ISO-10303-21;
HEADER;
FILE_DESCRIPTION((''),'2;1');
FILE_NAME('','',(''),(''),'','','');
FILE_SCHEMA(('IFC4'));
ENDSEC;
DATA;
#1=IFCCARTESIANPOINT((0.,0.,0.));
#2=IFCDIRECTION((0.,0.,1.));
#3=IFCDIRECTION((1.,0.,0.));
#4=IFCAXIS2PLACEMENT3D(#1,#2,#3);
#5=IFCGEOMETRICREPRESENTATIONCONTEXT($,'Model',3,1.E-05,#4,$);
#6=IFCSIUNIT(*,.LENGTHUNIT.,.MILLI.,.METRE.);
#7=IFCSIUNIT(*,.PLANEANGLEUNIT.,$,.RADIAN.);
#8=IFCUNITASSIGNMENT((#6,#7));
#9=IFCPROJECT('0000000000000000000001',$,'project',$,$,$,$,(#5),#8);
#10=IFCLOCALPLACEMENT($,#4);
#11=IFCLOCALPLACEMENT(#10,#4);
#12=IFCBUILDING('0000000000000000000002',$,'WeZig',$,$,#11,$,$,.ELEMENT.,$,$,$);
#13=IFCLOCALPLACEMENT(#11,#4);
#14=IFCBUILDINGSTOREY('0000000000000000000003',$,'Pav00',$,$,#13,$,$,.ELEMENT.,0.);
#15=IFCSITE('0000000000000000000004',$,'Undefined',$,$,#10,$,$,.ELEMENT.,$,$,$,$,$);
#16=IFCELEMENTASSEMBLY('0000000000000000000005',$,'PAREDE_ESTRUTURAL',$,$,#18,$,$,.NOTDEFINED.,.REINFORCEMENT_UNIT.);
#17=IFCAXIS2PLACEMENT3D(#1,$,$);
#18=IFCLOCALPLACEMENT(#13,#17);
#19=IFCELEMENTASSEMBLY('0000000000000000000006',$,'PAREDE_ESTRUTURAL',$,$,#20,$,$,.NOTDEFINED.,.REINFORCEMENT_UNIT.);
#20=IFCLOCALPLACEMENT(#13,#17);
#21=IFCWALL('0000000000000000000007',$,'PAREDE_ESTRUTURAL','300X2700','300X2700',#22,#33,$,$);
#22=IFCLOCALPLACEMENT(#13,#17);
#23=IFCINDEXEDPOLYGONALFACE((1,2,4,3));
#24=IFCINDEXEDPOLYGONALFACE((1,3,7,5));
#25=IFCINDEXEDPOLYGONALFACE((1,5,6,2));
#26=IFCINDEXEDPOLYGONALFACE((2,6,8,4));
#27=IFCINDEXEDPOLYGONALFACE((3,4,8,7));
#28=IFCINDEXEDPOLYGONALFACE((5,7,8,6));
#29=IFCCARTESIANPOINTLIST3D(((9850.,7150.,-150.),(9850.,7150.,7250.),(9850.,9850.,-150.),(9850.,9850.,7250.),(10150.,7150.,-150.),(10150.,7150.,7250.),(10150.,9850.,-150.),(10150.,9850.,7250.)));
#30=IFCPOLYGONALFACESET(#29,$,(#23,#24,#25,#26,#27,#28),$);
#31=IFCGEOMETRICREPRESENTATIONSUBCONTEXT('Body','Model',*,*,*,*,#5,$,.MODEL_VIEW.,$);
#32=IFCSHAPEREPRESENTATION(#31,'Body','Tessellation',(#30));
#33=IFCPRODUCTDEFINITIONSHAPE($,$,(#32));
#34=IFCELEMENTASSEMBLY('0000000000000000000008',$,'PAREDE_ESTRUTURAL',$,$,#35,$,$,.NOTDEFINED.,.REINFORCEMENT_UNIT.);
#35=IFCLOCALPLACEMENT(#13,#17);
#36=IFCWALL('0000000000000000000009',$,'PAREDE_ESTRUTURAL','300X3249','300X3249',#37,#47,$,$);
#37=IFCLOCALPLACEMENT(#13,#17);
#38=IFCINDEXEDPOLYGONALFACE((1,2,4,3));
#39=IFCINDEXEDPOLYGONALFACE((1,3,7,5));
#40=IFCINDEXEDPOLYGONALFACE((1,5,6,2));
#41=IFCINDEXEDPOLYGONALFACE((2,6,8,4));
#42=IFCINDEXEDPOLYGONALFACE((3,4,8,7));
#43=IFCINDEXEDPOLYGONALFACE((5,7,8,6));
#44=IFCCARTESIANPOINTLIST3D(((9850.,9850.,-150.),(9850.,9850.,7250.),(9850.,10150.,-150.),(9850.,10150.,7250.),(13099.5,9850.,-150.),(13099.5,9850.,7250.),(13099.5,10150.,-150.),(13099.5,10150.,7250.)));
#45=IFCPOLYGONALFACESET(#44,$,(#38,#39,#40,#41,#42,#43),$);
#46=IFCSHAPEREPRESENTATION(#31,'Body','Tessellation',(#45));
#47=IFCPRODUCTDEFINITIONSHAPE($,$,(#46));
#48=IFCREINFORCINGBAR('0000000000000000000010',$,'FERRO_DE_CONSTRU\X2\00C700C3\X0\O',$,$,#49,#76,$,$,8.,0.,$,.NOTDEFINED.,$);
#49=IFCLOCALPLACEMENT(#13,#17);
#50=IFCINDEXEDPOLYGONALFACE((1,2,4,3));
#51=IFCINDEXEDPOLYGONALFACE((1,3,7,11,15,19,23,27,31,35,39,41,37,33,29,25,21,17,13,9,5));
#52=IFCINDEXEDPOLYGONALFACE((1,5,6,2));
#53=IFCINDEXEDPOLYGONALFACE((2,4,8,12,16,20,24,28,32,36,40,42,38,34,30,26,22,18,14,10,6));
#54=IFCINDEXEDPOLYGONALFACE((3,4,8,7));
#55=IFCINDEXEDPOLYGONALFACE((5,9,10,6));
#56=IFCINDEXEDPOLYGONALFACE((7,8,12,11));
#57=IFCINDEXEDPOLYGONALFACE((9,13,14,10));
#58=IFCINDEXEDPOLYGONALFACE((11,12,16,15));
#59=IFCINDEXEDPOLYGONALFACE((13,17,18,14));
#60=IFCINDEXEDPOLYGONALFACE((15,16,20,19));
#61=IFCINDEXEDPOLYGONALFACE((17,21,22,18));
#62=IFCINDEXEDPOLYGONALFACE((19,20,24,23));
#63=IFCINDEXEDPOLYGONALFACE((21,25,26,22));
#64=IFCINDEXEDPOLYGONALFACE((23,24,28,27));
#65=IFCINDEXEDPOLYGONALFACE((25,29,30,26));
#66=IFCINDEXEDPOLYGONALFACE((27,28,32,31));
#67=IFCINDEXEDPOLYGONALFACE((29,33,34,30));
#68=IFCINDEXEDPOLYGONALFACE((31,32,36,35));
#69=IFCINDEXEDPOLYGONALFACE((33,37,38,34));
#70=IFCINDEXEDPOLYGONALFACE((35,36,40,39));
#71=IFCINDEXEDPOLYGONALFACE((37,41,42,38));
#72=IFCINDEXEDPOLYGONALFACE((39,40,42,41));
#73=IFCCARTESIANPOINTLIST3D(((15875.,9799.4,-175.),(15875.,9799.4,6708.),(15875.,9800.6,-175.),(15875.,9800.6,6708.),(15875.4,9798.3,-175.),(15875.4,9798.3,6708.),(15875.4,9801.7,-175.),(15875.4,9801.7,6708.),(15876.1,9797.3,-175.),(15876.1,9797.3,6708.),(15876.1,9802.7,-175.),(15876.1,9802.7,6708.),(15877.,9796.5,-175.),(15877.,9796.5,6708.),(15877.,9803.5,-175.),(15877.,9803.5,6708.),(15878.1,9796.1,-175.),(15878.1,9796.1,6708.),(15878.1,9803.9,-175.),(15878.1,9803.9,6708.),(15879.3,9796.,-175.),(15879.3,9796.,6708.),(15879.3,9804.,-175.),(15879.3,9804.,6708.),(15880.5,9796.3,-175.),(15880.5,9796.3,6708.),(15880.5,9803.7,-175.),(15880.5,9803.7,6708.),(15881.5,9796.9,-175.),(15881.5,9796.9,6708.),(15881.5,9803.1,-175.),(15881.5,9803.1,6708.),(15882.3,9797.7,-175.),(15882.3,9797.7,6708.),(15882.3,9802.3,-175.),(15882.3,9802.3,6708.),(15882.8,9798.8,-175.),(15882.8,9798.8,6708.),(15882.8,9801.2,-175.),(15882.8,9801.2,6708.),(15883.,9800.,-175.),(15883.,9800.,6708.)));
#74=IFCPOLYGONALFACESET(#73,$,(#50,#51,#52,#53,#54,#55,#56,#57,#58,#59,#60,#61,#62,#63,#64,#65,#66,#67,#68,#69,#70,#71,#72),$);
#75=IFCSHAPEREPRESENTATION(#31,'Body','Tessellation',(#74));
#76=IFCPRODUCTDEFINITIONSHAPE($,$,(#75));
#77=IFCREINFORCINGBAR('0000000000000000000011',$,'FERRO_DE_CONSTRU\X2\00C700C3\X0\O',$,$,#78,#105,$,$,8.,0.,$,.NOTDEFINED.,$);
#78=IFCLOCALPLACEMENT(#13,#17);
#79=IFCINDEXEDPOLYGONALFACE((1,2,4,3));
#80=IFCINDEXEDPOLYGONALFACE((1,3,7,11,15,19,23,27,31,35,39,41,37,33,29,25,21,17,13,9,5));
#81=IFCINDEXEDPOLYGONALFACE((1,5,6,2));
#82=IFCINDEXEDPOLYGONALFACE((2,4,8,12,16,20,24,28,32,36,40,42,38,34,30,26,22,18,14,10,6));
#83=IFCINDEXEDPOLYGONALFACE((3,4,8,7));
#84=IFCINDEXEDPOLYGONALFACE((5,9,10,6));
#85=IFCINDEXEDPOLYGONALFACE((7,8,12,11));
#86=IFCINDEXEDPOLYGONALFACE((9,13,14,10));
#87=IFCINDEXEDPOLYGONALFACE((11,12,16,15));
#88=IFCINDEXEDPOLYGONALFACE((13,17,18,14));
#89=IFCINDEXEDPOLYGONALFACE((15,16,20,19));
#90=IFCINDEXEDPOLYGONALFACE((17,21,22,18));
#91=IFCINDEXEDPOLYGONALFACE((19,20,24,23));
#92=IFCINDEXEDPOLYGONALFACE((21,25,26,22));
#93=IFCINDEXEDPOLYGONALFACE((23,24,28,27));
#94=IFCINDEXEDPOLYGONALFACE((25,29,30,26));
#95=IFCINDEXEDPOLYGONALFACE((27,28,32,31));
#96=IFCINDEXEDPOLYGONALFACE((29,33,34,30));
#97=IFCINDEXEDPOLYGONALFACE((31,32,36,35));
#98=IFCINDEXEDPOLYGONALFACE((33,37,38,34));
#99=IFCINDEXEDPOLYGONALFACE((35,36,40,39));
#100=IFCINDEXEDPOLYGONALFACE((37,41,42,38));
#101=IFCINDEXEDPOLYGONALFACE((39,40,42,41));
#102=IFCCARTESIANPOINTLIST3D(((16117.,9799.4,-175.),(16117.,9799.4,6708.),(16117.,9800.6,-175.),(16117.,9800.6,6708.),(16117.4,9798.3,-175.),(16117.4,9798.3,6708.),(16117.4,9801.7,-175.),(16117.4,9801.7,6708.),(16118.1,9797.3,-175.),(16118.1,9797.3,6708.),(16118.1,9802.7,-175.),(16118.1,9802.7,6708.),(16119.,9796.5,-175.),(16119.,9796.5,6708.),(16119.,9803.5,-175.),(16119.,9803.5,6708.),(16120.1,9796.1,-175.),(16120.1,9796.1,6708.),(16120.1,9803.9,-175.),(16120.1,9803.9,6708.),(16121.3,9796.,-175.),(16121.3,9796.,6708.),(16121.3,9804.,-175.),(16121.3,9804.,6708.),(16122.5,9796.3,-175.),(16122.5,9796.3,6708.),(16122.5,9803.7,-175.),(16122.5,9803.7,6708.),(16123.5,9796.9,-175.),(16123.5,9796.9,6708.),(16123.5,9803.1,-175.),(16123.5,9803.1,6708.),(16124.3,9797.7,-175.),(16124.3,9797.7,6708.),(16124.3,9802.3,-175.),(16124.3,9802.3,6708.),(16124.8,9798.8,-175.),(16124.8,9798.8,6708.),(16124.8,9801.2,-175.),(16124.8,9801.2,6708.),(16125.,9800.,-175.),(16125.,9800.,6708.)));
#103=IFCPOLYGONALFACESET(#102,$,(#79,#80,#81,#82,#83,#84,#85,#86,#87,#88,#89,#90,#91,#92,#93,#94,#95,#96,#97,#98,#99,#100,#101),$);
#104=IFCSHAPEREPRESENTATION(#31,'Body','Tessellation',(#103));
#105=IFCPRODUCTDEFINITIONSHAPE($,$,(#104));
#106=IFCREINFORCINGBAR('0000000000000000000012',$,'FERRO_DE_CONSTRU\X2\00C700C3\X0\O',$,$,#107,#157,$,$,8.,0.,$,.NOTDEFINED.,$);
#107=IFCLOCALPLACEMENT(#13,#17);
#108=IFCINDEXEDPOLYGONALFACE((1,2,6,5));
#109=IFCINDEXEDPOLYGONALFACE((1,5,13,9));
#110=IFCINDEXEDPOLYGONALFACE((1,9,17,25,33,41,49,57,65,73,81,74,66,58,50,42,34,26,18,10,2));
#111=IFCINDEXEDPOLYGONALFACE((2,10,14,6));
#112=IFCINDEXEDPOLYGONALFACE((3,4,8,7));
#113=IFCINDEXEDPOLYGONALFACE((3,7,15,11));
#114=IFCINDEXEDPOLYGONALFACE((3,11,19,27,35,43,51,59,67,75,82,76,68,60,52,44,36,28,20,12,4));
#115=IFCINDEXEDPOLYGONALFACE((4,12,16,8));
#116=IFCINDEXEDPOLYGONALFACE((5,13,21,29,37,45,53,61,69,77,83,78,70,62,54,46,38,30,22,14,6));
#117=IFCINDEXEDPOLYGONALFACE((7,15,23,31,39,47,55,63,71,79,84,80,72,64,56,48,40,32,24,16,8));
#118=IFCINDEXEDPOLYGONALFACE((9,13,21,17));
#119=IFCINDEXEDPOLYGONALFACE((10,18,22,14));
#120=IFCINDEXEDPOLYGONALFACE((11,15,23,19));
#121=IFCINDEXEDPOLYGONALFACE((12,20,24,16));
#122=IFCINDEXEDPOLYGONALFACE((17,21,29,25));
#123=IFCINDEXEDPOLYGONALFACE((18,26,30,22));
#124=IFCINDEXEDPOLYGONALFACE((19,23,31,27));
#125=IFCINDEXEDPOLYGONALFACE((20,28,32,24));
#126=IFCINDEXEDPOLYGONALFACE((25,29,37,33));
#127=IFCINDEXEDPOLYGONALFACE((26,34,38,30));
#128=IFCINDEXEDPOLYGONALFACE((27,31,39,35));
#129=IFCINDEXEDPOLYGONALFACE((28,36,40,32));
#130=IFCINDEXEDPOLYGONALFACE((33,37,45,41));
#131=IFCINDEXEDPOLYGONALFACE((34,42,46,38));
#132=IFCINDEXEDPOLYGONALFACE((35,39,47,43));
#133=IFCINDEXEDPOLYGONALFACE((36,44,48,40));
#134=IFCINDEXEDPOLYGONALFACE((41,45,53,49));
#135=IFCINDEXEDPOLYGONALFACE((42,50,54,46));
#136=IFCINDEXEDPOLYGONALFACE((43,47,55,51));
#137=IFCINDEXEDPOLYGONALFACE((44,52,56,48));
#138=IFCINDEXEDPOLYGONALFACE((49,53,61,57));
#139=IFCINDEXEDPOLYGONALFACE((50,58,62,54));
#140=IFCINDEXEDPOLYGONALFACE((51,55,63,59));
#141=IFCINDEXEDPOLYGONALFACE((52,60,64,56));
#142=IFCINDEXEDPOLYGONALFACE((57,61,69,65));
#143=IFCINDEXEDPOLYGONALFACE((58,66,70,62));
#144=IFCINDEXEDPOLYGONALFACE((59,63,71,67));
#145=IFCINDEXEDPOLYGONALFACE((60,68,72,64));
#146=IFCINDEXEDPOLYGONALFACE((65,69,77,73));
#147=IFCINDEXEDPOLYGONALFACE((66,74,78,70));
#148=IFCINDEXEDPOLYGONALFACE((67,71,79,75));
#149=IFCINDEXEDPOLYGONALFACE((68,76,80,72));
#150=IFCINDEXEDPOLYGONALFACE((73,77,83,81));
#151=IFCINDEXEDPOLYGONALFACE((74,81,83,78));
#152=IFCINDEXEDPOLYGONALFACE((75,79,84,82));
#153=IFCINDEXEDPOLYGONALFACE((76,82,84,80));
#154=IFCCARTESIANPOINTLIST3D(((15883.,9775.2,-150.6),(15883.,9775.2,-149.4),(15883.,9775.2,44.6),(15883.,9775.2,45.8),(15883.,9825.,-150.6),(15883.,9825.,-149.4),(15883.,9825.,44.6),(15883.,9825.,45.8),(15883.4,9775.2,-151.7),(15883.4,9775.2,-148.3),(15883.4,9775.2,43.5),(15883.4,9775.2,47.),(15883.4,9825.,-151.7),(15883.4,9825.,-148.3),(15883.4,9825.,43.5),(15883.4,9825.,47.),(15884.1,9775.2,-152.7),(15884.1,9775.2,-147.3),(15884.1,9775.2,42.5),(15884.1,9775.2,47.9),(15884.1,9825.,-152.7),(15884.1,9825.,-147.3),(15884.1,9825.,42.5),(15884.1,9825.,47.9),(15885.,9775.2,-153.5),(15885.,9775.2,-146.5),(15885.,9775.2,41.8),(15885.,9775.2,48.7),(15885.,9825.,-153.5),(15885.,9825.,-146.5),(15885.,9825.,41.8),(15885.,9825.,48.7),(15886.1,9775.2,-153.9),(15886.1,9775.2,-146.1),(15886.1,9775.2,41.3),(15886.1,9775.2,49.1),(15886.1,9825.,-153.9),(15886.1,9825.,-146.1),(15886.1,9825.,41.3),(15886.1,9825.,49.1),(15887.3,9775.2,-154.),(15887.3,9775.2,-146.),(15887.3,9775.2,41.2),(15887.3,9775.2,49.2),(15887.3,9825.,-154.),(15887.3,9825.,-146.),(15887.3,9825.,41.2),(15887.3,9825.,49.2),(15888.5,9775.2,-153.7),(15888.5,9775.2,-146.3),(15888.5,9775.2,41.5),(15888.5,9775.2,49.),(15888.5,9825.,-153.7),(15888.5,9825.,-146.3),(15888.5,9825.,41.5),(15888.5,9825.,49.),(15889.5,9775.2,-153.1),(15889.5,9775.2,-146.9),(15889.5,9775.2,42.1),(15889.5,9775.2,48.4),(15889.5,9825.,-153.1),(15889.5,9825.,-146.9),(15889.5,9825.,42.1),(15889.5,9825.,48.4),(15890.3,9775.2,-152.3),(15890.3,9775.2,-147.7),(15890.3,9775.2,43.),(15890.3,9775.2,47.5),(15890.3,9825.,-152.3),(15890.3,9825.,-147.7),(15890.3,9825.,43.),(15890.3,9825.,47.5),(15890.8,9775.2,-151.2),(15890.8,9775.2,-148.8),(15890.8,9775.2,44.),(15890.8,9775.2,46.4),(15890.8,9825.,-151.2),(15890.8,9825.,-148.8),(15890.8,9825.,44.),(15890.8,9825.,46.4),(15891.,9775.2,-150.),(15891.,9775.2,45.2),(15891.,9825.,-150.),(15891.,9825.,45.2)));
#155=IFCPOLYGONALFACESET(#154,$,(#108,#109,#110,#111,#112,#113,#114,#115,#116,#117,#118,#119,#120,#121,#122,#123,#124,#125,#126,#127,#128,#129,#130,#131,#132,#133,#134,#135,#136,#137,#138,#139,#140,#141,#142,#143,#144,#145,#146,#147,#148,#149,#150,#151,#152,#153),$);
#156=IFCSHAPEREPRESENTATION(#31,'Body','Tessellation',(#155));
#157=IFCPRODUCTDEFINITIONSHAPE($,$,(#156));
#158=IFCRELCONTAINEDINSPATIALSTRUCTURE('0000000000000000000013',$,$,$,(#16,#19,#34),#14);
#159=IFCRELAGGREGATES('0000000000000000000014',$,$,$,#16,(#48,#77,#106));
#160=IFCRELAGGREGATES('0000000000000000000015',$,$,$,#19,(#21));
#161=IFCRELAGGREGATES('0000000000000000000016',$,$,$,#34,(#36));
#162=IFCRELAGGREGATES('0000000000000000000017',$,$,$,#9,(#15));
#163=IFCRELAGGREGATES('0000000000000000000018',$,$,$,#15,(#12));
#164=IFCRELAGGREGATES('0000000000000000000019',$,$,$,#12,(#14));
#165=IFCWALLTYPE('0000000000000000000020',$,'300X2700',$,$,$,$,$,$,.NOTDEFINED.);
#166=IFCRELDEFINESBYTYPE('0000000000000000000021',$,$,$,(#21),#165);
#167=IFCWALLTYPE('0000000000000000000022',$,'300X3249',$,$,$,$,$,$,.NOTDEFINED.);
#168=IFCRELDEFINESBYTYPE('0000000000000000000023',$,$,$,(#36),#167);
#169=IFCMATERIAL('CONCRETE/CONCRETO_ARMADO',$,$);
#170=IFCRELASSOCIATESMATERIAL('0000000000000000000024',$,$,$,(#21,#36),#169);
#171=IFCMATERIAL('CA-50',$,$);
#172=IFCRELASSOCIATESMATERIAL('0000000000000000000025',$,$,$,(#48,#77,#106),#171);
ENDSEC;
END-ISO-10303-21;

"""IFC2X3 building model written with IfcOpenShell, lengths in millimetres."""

from ifc_helpers import new_model, entity, si_unit, frame, frame_2d, origin_with_axes, place, context, subcontext, project, spatial, rectangle, extrude, source, transform, mapped, material, type_object, element, aggregate, save


model = new_model("IFC2X3")

# Units and contexts
model_context = context("Model", 3, precision=1e-05, world=origin_with_axes())
body_context = subcontext(model_context, "Body", "Model", "MODEL_VIEW")
ifc_project = project(units=[si_unit("LENGTHUNIT", "METRE", prefix="MILLI"), si_unit("PLANEANGLEUNIT", "RADIAN")], contexts=[model_context])

# Site, building, storey
site_placement = place(None, origin_with_axes())
site = spatial("IfcSite", under=ifc_project, at=site_placement, Name="Undefined", CompositionType="ELEMENT")
building_placement = place(site_placement, origin_with_axes())
building = spatial("IfcBuilding", under=site, at=building_placement, Name="WeZig", CompositionType="ELEMENT")
storey_placement = place(building_placement, origin_with_axes())
storey = spatial("IfcBuildingStorey", under=building, at=storey_placement, Name="Pav00", CompositionType="ELEMENT", Elevation=0.0)

# Element assemblies, walls
assembly_1_placement = place(storey_placement, origin_with_axes())
assembly_1 = element("IfcElementAssembly", 1, at=assembly_1_placement, inside=storey, Name="PAREDE_ESTRUTURAL", AssemblyPlace="NOTDEFINED", PredefinedType="REINFORCEMENT_UNIT")
ifc_material_1 = material(Name="CONCRETE/CONCRETO_ARMADO")
wall_type_1 = type_object("IfcWallType", Name="300X2700", PredefinedType="NOTDEFINED")
assembly_2_placement = place(storey_placement, origin_with_axes())
assembly_2 = element("IfcElementAssembly", 2, at=assembly_2_placement, inside=storey, Name="PAREDE_ESTRUTURAL", AssemblyPlace="NOTDEFINED", PredefinedType="REINFORCEMENT_UNIT")
wall_1_placement = place(assembly_2_placement, frame((10000.0, 9850.0, 2200.0), z_axis=(0.0, 0.0, 1.0), x_axis=(0.0, -1.0, 0.0)))
wall_1 = element("IfcWall", 3, at=wall_1_placement, type_object=wall_type_1, material=ifc_material_1, Name="PAREDE_ESTRUTURAL", Description="300X2700", ObjectType="300X2700", context=body_context, shape_type="SweptSolid", body=[
    extrude(rectangle(XDim=2700.0, YDim=300.0, at=frame_2d((0.0, 1350.0), x_axis=(0.0, -1.0))), frame((0.0, 0.0, -2350.0), z_axis=(0.0, 0.0, 1.0), x_axis=(0.0, -1.0, 0.0)), (0.0, 0.0, 1.0), 7400.0),
])
assembly_3_placement = place(storey_placement, origin_with_axes())
assembly_3 = element("IfcElementAssembly", 4, at=assembly_3_placement, inside=storey, Name="PAREDE_ESTRUTURAL", AssemblyPlace="NOTDEFINED", PredefinedType="REINFORCEMENT_UNIT")
wall_type_2 = type_object("IfcWallType", Name="300X3249", PredefinedType="NOTDEFINED")
wall_2_placement = place(assembly_3_placement, frame((13099.5, 10000.0, 1925.2), z_axis=(0.0, 0.0, 1.0), x_axis=(-1.0, 0.0, 0.0)))
wall_2 = element("IfcWall", 5, at=wall_2_placement, type_object=wall_type_2, material=ifc_material_1, Name="PAREDE_ESTRUTURAL", Description="300X3249", ObjectType="300X3249", context=body_context, shape_type="SweptSolid", body=[
    extrude(rectangle(XDim=3249.5, YDim=300.0, at=frame_2d((0.0, 1624.8), x_axis=(0.0, -1.0))), frame((0.0, 0.0, -2075.2), z_axis=(0.0, 0.0, 1.0), x_axis=(0.0, -1.0, 0.0)), (0.0, 0.0, 1.0), 7400.0),
])

# Reinforcing bars
ifc_material_2 = material(Name="CA-50")
shared_shape_1 = source(origin_with_axes(), body_context, "Body", "AdvancedSweptSolid", [
    entity("IfcSweptDiskSolid", entity("IfcTrimmedCurve", entity("IfcLine", entity("IfcCartesianPoint", [0.0, 0.0, 0.0]), entity("IfcVector", entity("IfcDirection", [1.0, 0.0, 0.0]), 1.0)), [entity("IfcParameterValue", 0.0)], [entity("IfcParameterValue", 6883.0)], True, "PARAMETER"), 4.0, None, 0.0, 6883.0),
])
reinforcing_bar_1_placement = place(assembly_1_placement, frame((15879.0, 9800.0, 6708.0), z_axis=(1.0, 0.0, 0.0), x_axis=(0.0, 0.0, -1.0)))
reinforcing_bar_1 = element("IfcReinforcingBar", 6, at=reinforcing_bar_1_placement, material=ifc_material_2, Name="FERRO_DE_CONSTRUÇÃO", BarRole="NOTDEFINED", CrossSectionArea=0.0, NominalDiameter=8.0, context=body_context, shape_type="MappedRepresentation", body=[
    mapped(shared_shape_1, transform((0.0, 0.0, 0.0))),
])
shared_shape_2 = source(origin_with_axes(), body_context, "Body", "AdvancedSweptSolid", [
    entity("IfcSweptDiskSolid", entity("IfcTrimmedCurve", entity("IfcLine", entity("IfcCartesianPoint", [0.0, 0.0, 0.0]), entity("IfcVector", entity("IfcDirection", [1.0, 0.0, 0.0]), 1.0)), [entity("IfcParameterValue", 0.0)], [entity("IfcParameterValue", 6883.0)], True, "PARAMETER"), 4.0, None, 0.0, 6883.0),
])
reinforcing_bar_2_placement = place(assembly_1_placement, frame((16121.0, 9800.0, 6708.0), z_axis=(1.0, 0.0, 0.0), x_axis=(0.0, 0.0, -1.0)))
reinforcing_bar_2 = element("IfcReinforcingBar", 7, at=reinforcing_bar_2_placement, material=ifc_material_2, Name="FERRO_DE_CONSTRUÇÃO", BarRole="NOTDEFINED", CrossSectionArea=0.0, NominalDiameter=8.0, context=body_context, shape_type="MappedRepresentation", body=[
    mapped(shared_shape_2, transform((0.0, 0.0, 0.0))),
])
shared_shape_3 = source(origin_with_axes(), body_context, "Body", "AdvancedSweptSolid", [
    entity("IfcSweptDiskSolid", entity("IfcTrimmedCurve", entity("IfcLine", entity("IfcCartesianPoint", [0.0, 0.0, 0.0]), entity("IfcVector", entity("IfcDirection", [1.0, 0.0, 0.0]), 1.0)), [entity("IfcParameterValue", 0.0)], [entity("IfcParameterValue", 49.804876)], True, "PARAMETER"), 4.0, None, 0.0, 49.8),
])
shared_shape_4 = source(origin_with_axes(), body_context, "Body", "AdvancedSweptSolid", [
    entity("IfcSweptDiskSolid", entity("IfcTrimmedCurve", entity("IfcLine", entity("IfcCartesianPoint", [0.0, 0.0, 0.0]), entity("IfcVector", entity("IfcDirection", [1.0, 0.0, 0.0]), 1.0)), [entity("IfcParameterValue", 0.0)], [entity("IfcParameterValue", 49.804876)], True, "PARAMETER"), 4.0, None, 0.0, 49.8),
])
reinforcing_bar_3_placement = place(assembly_1_placement, frame((15887.0, 9825.0, 45.2), z_axis=(1.0, 0.0, 0.0), x_axis=(0.0, -1.0, 0.0)))
reinforcing_bar_3 = element("IfcReinforcingBar", 8, at=reinforcing_bar_3_placement, material=ifc_material_2, Name="FERRO_DE_CONSTRUÇÃO", BarRole="NOTDEFINED", CrossSectionArea=0.0, NominalDiameter=8.0, context=body_context, shape_type="MappedRepresentation", body=[
    mapped(shared_shape_3, transform((0.0, 0.0, 0.0))),
    mapped(shared_shape_4, transform((0.0, 195.2, 0.0))),
])
aggregate(assembly_1, [reinforcing_bar_1, reinforcing_bar_2, reinforcing_bar_3])
aggregate(assembly_2, [wall_1])
aggregate(assembly_3, [wall_2])

save(model, "model.ifc")
